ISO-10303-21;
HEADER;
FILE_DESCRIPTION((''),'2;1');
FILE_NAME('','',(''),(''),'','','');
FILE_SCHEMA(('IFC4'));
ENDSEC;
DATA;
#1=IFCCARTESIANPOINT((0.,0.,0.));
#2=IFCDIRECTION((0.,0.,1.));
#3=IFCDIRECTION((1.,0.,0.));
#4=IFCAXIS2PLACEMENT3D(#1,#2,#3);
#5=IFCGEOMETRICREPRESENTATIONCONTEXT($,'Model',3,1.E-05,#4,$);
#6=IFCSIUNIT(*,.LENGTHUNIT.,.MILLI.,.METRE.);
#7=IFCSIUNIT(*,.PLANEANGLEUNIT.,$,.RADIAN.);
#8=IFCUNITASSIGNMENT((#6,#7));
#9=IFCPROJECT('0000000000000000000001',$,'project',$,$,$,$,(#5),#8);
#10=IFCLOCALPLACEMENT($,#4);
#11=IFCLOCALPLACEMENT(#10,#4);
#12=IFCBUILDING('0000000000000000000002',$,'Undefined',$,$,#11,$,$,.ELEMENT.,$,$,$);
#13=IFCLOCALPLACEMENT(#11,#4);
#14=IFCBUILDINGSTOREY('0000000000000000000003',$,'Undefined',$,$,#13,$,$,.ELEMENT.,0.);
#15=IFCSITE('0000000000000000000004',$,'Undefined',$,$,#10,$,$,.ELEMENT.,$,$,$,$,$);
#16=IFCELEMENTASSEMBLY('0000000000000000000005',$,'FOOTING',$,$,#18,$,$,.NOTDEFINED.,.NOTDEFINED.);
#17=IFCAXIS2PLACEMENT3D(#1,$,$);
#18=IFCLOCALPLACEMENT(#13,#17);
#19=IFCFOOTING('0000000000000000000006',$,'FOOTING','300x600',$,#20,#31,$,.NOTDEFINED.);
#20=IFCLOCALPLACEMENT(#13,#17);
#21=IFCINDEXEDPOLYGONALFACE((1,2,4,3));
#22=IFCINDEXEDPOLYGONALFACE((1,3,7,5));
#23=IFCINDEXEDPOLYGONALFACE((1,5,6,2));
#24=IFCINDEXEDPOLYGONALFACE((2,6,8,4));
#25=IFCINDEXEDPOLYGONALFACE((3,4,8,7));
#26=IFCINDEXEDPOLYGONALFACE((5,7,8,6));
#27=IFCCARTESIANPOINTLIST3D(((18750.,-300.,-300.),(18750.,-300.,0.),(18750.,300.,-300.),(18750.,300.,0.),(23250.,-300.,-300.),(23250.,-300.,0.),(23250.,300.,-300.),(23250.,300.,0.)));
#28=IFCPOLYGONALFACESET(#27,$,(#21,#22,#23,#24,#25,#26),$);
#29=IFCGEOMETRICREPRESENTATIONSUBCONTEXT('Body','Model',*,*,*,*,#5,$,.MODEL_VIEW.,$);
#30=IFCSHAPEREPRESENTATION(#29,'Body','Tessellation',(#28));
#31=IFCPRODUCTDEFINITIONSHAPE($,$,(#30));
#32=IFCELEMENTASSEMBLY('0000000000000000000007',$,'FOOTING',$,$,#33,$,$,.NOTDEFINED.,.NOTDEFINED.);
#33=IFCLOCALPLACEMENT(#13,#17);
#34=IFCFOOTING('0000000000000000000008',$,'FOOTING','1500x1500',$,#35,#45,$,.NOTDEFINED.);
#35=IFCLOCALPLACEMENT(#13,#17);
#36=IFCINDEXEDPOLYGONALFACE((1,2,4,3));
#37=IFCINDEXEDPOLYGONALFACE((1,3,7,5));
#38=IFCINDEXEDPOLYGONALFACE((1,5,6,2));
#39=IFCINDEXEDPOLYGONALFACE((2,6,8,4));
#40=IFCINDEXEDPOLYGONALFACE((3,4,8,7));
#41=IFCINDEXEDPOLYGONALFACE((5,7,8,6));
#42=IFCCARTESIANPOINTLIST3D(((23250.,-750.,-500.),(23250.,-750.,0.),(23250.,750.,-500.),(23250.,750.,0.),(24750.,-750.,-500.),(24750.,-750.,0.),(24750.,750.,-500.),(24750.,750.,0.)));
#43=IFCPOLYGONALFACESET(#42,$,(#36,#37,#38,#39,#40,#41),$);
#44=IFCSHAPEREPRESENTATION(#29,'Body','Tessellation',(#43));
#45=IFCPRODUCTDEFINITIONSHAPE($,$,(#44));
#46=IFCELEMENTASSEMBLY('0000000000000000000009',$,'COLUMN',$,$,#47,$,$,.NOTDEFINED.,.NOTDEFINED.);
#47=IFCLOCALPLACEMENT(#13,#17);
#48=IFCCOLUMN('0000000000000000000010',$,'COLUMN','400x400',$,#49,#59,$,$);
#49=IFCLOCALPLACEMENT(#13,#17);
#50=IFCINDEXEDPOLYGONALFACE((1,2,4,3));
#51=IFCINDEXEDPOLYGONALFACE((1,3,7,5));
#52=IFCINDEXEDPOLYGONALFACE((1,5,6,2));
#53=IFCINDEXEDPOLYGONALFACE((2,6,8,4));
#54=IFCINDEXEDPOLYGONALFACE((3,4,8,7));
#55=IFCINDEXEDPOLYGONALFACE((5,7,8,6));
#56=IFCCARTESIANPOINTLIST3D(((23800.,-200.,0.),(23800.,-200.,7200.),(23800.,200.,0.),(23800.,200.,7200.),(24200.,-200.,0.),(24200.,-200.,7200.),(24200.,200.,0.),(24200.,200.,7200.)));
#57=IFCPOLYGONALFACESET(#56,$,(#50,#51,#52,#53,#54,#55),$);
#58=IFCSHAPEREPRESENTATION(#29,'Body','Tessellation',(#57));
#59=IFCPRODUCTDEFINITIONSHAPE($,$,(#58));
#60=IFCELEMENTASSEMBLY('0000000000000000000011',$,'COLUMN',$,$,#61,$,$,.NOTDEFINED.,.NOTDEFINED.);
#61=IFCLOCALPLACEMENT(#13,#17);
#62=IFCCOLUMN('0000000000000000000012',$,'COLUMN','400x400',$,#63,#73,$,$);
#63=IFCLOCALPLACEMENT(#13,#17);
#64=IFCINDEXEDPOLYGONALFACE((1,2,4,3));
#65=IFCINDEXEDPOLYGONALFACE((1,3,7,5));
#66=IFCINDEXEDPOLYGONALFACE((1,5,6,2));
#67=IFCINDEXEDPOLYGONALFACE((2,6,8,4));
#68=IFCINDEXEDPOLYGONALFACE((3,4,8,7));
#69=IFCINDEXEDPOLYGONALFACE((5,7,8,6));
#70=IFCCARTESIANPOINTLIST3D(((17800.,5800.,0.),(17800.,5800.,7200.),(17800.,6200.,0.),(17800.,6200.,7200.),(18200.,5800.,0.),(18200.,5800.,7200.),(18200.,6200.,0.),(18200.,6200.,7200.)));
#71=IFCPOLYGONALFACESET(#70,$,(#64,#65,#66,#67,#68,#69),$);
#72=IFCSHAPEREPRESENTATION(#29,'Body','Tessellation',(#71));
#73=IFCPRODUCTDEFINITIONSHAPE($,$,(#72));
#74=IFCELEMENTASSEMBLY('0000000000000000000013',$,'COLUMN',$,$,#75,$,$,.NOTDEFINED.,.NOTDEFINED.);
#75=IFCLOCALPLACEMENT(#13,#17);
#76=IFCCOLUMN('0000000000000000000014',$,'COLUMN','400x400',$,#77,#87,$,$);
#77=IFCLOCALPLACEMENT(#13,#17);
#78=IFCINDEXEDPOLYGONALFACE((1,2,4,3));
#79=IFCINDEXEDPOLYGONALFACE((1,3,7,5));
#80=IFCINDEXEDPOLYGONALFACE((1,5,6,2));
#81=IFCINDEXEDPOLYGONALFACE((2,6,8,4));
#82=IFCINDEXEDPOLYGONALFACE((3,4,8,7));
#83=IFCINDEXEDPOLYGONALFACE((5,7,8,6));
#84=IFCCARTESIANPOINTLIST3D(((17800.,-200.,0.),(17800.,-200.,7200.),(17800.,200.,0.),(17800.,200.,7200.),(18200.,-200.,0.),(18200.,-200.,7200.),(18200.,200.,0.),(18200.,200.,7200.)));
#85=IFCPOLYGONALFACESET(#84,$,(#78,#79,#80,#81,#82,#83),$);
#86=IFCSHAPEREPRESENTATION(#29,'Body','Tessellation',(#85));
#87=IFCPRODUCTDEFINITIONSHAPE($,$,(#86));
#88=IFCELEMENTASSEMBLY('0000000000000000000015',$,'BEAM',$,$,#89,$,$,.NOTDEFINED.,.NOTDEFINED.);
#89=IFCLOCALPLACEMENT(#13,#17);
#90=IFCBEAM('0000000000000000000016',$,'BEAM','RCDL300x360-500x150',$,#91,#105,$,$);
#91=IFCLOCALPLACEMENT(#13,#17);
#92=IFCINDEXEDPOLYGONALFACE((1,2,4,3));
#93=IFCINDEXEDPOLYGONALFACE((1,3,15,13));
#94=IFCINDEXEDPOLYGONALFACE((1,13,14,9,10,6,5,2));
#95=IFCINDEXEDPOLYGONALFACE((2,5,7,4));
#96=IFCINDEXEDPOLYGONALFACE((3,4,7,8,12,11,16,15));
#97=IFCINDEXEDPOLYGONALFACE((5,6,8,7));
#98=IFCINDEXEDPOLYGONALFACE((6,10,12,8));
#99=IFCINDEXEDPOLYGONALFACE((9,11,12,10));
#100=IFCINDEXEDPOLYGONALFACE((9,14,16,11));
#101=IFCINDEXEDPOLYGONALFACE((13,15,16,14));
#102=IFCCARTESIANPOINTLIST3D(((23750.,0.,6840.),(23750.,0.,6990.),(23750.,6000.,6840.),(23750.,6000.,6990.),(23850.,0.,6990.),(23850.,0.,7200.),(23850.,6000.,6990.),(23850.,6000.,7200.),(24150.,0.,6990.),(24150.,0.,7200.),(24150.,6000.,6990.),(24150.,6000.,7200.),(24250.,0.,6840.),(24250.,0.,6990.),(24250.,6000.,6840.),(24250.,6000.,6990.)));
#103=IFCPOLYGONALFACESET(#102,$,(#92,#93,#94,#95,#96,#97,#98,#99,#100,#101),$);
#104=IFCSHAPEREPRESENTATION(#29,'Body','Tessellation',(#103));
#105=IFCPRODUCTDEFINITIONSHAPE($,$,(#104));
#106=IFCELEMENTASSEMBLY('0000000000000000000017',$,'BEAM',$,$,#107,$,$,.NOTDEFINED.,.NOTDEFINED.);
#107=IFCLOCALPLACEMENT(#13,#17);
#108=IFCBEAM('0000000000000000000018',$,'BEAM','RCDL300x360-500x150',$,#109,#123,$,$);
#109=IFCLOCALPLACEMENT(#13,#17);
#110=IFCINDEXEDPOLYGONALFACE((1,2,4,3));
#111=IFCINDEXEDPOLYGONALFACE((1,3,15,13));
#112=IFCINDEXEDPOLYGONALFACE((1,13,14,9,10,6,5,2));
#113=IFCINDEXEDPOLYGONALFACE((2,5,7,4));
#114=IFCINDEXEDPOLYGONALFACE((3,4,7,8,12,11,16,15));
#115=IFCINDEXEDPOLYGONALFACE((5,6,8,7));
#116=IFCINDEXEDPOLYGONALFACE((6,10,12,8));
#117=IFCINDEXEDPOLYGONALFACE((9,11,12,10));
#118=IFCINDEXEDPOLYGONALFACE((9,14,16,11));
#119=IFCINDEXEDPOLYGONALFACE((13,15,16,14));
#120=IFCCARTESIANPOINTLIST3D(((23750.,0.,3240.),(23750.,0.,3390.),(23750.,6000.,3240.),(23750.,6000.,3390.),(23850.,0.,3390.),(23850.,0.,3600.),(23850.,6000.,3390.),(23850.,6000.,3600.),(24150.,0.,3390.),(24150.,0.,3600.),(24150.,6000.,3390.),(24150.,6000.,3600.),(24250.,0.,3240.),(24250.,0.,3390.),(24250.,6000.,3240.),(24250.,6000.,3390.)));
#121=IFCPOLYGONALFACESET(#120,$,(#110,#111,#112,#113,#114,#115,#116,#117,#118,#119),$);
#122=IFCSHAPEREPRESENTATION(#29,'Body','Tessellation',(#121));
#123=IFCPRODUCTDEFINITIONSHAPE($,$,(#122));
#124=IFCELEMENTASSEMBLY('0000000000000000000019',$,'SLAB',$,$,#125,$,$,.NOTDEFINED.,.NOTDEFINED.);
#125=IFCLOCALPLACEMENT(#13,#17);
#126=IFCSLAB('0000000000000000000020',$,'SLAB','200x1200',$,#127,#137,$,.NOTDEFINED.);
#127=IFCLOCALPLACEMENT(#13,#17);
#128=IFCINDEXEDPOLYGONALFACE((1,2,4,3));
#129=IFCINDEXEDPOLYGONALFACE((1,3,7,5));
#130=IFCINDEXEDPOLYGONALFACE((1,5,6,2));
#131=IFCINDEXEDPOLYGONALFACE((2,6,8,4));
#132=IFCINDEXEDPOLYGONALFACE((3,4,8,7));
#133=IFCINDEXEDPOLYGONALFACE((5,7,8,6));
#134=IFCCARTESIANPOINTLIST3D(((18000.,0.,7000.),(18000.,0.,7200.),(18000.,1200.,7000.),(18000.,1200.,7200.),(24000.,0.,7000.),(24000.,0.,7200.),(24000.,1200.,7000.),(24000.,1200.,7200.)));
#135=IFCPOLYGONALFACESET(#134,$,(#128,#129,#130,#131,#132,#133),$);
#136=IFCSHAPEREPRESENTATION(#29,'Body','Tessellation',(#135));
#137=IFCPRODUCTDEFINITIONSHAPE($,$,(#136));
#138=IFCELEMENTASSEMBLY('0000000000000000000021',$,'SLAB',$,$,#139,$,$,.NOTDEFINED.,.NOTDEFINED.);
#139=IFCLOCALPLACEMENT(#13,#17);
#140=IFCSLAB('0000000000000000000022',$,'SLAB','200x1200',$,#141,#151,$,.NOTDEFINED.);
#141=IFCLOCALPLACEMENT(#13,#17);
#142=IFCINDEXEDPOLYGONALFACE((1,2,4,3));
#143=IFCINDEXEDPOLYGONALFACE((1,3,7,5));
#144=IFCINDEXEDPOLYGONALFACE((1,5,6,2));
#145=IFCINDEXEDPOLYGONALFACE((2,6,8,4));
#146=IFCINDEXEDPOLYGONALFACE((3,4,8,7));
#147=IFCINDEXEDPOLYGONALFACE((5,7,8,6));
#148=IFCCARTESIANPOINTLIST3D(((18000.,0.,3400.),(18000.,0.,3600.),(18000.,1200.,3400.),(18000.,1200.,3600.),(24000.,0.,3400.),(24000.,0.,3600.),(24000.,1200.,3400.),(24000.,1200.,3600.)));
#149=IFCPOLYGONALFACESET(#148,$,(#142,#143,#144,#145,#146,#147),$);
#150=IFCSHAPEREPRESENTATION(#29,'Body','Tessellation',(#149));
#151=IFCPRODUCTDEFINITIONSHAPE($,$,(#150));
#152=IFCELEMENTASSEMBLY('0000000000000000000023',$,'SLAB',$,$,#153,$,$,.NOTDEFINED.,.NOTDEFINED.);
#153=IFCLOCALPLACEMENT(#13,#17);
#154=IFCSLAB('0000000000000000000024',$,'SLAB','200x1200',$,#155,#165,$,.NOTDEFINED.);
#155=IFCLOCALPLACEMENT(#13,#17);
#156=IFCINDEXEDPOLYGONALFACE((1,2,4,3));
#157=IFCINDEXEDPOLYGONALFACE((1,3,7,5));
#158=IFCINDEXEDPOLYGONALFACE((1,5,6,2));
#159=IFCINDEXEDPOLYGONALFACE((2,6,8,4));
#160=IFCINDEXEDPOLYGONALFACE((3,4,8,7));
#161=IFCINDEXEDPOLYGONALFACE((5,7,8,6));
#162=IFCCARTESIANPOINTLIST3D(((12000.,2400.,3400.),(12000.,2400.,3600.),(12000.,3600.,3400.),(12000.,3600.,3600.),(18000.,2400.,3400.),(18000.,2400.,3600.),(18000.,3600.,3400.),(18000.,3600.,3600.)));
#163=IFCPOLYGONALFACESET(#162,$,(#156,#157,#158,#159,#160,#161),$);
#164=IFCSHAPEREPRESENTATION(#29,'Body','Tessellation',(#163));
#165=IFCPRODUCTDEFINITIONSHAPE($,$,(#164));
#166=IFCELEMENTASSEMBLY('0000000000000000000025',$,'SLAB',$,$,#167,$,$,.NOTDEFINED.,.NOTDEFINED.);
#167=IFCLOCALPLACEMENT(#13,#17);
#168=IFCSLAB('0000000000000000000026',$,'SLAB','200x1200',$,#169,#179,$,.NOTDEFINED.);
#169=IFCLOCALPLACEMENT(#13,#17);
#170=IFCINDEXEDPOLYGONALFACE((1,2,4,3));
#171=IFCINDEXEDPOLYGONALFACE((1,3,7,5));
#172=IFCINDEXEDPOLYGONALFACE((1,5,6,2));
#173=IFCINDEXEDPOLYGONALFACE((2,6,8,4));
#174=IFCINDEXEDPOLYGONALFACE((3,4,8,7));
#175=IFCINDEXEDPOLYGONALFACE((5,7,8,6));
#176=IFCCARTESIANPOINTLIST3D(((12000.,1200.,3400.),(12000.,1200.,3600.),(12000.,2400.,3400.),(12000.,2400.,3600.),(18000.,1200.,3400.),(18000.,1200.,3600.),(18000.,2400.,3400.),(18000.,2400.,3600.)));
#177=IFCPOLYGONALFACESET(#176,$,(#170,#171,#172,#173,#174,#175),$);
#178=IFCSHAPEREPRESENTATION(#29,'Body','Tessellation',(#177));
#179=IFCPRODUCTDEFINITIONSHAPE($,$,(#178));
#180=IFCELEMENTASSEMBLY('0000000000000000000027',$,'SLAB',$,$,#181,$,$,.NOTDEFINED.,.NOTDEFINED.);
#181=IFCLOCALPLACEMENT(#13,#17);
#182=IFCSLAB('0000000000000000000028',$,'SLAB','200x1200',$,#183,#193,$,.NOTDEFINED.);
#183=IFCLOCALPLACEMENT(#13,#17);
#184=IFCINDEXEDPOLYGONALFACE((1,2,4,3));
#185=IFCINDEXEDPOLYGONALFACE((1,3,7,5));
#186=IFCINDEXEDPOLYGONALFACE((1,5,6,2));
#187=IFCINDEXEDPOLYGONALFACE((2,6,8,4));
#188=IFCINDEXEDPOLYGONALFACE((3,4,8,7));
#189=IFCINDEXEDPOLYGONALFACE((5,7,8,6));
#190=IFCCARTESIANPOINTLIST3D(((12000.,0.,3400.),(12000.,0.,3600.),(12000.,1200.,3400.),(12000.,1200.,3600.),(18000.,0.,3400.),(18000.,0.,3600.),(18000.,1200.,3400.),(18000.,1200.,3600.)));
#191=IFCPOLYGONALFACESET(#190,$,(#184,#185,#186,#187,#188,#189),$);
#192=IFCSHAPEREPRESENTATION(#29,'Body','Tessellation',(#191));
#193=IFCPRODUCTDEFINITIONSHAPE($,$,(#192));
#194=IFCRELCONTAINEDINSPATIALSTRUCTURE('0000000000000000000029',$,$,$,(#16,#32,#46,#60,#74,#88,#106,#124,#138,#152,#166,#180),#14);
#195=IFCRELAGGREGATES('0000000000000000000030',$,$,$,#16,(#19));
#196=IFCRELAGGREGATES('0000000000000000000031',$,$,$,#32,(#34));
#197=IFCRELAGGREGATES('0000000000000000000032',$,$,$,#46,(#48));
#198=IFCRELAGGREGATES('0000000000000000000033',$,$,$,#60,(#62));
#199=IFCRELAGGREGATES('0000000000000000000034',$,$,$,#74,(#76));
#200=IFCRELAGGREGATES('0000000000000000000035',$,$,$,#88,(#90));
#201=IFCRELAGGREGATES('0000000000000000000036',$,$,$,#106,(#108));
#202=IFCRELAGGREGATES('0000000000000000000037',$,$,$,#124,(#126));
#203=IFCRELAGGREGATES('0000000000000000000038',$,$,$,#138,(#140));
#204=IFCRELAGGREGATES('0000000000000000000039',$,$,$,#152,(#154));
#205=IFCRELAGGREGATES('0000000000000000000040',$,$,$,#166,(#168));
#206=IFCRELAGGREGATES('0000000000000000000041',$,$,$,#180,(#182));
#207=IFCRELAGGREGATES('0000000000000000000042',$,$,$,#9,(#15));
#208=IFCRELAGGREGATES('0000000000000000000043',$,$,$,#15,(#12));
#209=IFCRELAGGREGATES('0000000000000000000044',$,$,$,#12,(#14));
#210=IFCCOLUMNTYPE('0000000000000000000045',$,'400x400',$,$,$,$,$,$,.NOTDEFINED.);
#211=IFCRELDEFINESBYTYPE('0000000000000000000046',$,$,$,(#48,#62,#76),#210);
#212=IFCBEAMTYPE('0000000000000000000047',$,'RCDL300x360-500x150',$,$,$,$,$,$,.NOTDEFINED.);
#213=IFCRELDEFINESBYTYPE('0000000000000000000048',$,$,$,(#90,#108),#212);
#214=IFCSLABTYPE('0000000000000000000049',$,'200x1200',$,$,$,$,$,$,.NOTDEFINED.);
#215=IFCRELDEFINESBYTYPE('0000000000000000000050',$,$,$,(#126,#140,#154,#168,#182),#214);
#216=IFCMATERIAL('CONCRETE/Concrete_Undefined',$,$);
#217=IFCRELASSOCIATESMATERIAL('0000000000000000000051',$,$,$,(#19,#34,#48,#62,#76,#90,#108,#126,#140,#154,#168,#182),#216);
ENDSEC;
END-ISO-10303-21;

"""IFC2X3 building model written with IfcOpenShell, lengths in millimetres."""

from ifc_helpers import new_model, si_unit, frame, origin_with_axes, origin_2d_with_axis, place, context, subcontext, project, spatial, polyline, rectangle, outline, extrude, material, type_object, element, aggregate, save


model = new_model("IFC2X3")

# Units and contexts
model_context = context("Model", 3, precision=1e-05, world=origin_with_axes())
body_context = subcontext(model_context, "Body", "Model", "MODEL_VIEW")
ifc_project = project(units=[si_unit("LENGTHUNIT", "METRE", prefix="MILLI"), si_unit("PLANEANGLEUNIT", "RADIAN")], contexts=[model_context])

# Site, building, storey
site_placement = place(None, origin_with_axes())
site = spatial("IfcSite", under=ifc_project, at=site_placement, Name="Undefined", CompositionType="ELEMENT")
building_placement = place(site_placement, origin_with_axes())
building = spatial("IfcBuilding", under=site, at=building_placement, Name="Undefined", CompositionType="ELEMENT")
storey_placement = place(building_placement, origin_with_axes())
storey = spatial("IfcBuildingStorey", under=building, at=storey_placement, Name="Undefined", CompositionType="ELEMENT", Elevation=0.0)

# Element assemblies, footings
assembly_1_placement = place(storey_placement, origin_with_axes())
assembly_1 = element("IfcElementAssembly", 1, at=assembly_1_placement, inside=storey, Name="FOOTING", AssemblyPlace="NOTDEFINED", PredefinedType="NOTDEFINED")
ifc_material_1 = material(Name="CONCRETE/Concrete_Undefined")
footing_1_placement = place(assembly_1_placement, frame((18750.0, 0.0, -150.0), z_axis=(0.0, 0.0, 1.0), x_axis=(1.0, 0.0, 0.0)))
footing_1 = element("IfcFooting", 2, at=footing_1_placement, material=ifc_material_1, Name="FOOTING", Description="300x600", PredefinedType="NOTDEFINED", context=body_context, shape_type="SweptSolid", body=[
    extrude(rectangle(XDim=600.0, YDim=300.0, at=origin_2d_with_axis()), frame((4500.0, 0.0, 0.0), z_axis=(-1.0, 0.0, 0.0), x_axis=(0.0, -1.0, 0.0)), (0.0, 0.0, 1.0), 4500.0),
])
aggregate(assembly_1, [footing_1])
assembly_2_placement = place(storey_placement, origin_with_axes())
assembly_2 = element("IfcElementAssembly", 3, at=assembly_2_placement, inside=storey, Name="FOOTING", AssemblyPlace="NOTDEFINED", PredefinedType="NOTDEFINED")
footing_2_placement = place(assembly_2_placement, frame((24000.0, 0.0, -500.0), z_axis=(0.0, 1.0, 0.0), x_axis=(0.0, 0.0, 1.0)))
footing_2 = element("IfcFooting", 4, at=footing_2_placement, material=ifc_material_1, Name="FOOTING", Description="1500x1500", PredefinedType="NOTDEFINED", context=body_context, shape_type="SweptSolid", body=[
    extrude(rectangle(XDim=1500.0, YDim=1500.0, at=origin_2d_with_axis()), frame((500.0, 0.0, 0.0), z_axis=(-1.0, 0.0, 0.0), x_axis=(0.0, -1.0, 0.0)), (0.0, 0.0, 1.0), 500.0),
])
aggregate(assembly_2, [footing_2])

# Element assemblies, columns
assembly_3_placement = place(storey_placement, origin_with_axes())
assembly_3 = element("IfcElementAssembly", 5, at=assembly_3_placement, inside=storey, Name="COLUMN", AssemblyPlace="NOTDEFINED", PredefinedType="NOTDEFINED")
column_type = type_object("IfcColumnType", Name="400x400", PredefinedType="NOTDEFINED")
column_1_placement = place(assembly_3_placement, frame((24000.0, 0.0, 0.0), z_axis=(0.0, 0.0, 1.0), x_axis=(0.0, 1.0, 0.0)))
column_1 = element("IfcColumn", 6, at=column_1_placement, type_object=column_type, material=ifc_material_1, Name="COLUMN", Description="400x400", context=body_context, shape_type="SweptSolid", body=[
    extrude(rectangle(XDim=400.0, YDim=400.0, at=origin_2d_with_axis()), frame((0.0, 0.0, 7200.0), z_axis=(0.0, 0.0, -1.0), x_axis=(0.0, 1.0, 0.0)), (0.0, 0.0, 1.0), 7200.0),
])
aggregate(assembly_3, [column_1])
assembly_4_placement = place(storey_placement, origin_with_axes())
assembly_4 = element("IfcElementAssembly", 7, at=assembly_4_placement, inside=storey, Name="COLUMN", AssemblyPlace="NOTDEFINED", PredefinedType="NOTDEFINED")
column_2_placement = place(assembly_4_placement, frame((18000.0, 6000.0, 0.0), z_axis=(0.0, 0.0, 1.0), x_axis=(0.0, 1.0, 0.0)))
column_2 = element("IfcColumn", 8, at=column_2_placement, type_object=column_type, material=ifc_material_1, Name="COLUMN", Description="400x400", context=body_context, shape_type="SweptSolid", body=[
    extrude(rectangle(XDim=400.0, YDim=400.0, at=origin_2d_with_axis()), frame((0.0, 0.0, 7200.0), z_axis=(0.0, 0.0, -1.0), x_axis=(0.0, 1.0, 0.0)), (0.0, 0.0, 1.0), 7200.0),
])
aggregate(assembly_4, [column_2])
assembly_5_placement = place(storey_placement, origin_with_axes())
assembly_5 = element("IfcElementAssembly", 9, at=assembly_5_placement, inside=storey, Name="COLUMN", AssemblyPlace="NOTDEFINED", PredefinedType="NOTDEFINED")
column_3_placement = place(assembly_5_placement, frame((18000.0, 0.0, 0.0), z_axis=(0.0, 0.0, 1.0), x_axis=(0.0, 1.0, 0.0)))
column_3 = element("IfcColumn", 10, at=column_3_placement, type_object=column_type, material=ifc_material_1, Name="COLUMN", Description="400x400", context=body_context, shape_type="SweptSolid", body=[
    extrude(rectangle(XDim=400.0, YDim=400.0, at=origin_2d_with_axis()), frame((0.0, 0.0, 7200.0), z_axis=(0.0, 0.0, -1.0), x_axis=(0.0, 1.0, 0.0)), (0.0, 0.0, 1.0), 7200.0),
])
aggregate(assembly_5, [column_3])

# Element assemblies, beams
assembly_6_placement = place(storey_placement, origin_with_axes())
assembly_6 = element("IfcElementAssembly", 11, at=assembly_6_placement, inside=storey, Name="BEAM", AssemblyPlace="NOTDEFINED", PredefinedType="NOTDEFINED")
beam_type_1 = type_object("IfcBeamType", Name="RCDL300x360-500x150", PredefinedType="NOTDEFINED")
beam_1_placement = place(assembly_6_placement, frame((24000.0, 0.0, 7020.0), z_axis=(0.0, 0.0, 1.0), x_axis=(0.0, 1.0, 0.0)))
beam_1 = element("IfcBeam", 12, at=beam_1_placement, type_object=beam_type_1, material=ifc_material_1, Name="BEAM", Description="RCDL300x360-500x150", context=body_context, shape_type="SweptSolid", body=[
    extrude(outline(polyline([(150.0, 180.0), (150.0, -30.0), (250.0, -30.0), (250.0, -180.0), (-250.0, -180.0), (-250.0, -30.0), (-150.0, -30.0), (-150.0, 180.0), (150.0, 180.0)])), frame((6000.0, 0.0, 0.0), z_axis=(-1.0, 0.0, 0.0), x_axis=(0.0, -1.0, 0.0)), (0.0, 0.0, 1.0), 6000.0),
])
aggregate(assembly_6, [beam_1])
assembly_7_placement = place(storey_placement, origin_with_axes())
assembly_7 = element("IfcElementAssembly", 13, at=assembly_7_placement, inside=storey, Name="BEAM", AssemblyPlace="NOTDEFINED", PredefinedType="NOTDEFINED")
beam_2_placement = place(assembly_7_placement, frame((24000.0, 0.0, 3420.0), z_axis=(0.0, 0.0, 1.0), x_axis=(0.0, 1.0, 0.0)))
beam_2 = element("IfcBeam", 14, at=beam_2_placement, type_object=beam_type_1, material=ifc_material_1, Name="BEAM", Description="RCDL300x360-500x150", context=body_context, shape_type="SweptSolid", body=[
    extrude(outline(polyline([(150.0, 180.0), (150.0, -30.0), (250.0, -30.0), (250.0, -180.0), (-250.0, -180.0), (-250.0, -30.0), (-150.0, -30.0), (-150.0, 180.0), (150.0, 180.0)])), frame((6000.0, 0.0, 0.0), z_axis=(-1.0, 0.0, 0.0), x_axis=(0.0, -1.0, 0.0)), (0.0, 0.0, 1.0), 6000.0),
])
aggregate(assembly_7, [beam_2])

# Element assemblies, slabs
assembly_8_placement = place(storey_placement, origin_with_axes())
assembly_8 = element("IfcElementAssembly", 15, at=assembly_8_placement, inside=storey, Name="SLAB", AssemblyPlace="NOTDEFINED", PredefinedType="NOTDEFINED")
slab_type = type_object("IfcSlabType", Name="200x1200", PredefinedType="NOTDEFINED")
slab_1_placement = place(assembly_8_placement, frame((24000.0, 0.0, 7100.0), z_axis=(0.0, 0.0, 1.0), x_axis=(0.0, 1.0, 0.0)))
slab_1 = element("IfcSlab", 16, at=slab_1_placement, type_object=slab_type, material=ifc_material_1, Name="SLAB", Description="200x1200", PredefinedType="NOTDEFINED", context=body_context, shape_type="SweptSolid", body=[
    extrude(outline(polyline([(0.0, 0.0), (1200.0, 0.0), (1200.0, 6000.0), (0.0, 6000.0), (0.0, 0.0)])), frame((0.0, 0.0, -100.0), z_axis=(0.0, 0.0, 1.0), x_axis=(1.0, 0.0, 0.0)), (0.0, 0.0, 1.0), 200.0),
])
aggregate(assembly_8, [slab_1])
assembly_9_placement = place(storey_placement, origin_with_axes())
assembly_9 = element("IfcElementAssembly", 17, at=assembly_9_placement, inside=storey, Name="SLAB", AssemblyPlace="NOTDEFINED", PredefinedType="NOTDEFINED")
slab_2_placement = place(assembly_9_placement, frame((24000.0, 0.0, 3500.0), z_axis=(0.0, 0.0, 1.0), x_axis=(0.0, 1.0, 0.0)))
slab_2 = element("IfcSlab", 18, at=slab_2_placement, type_object=slab_type, material=ifc_material_1, Name="SLAB", Description="200x1200", PredefinedType="NOTDEFINED", context=body_context, shape_type="SweptSolid", body=[
    extrude(outline(polyline([(0.0, 0.0), (1200.0, 0.0), (1200.0, 6000.0), (0.0, 6000.0), (0.0, 0.0)])), frame((0.0, 0.0, -100.0), z_axis=(0.0, 0.0, 1.0), x_axis=(1.0, 0.0, 0.0)), (0.0, 0.0, 1.0), 200.0),
])
aggregate(assembly_9, [slab_2])
assembly_10_placement = place(storey_placement, origin_with_axes())
assembly_10 = element("IfcElementAssembly", 19, at=assembly_10_placement, inside=storey, Name="SLAB", AssemblyPlace="NOTDEFINED", PredefinedType="NOTDEFINED")
slab_3_placement = place(assembly_10_placement, frame((18000.0, 2400.0, 3500.0), z_axis=(0.0, 0.0, 1.0), x_axis=(0.0, 1.0, 0.0)))
slab_3 = element("IfcSlab", 20, at=slab_3_placement, type_object=slab_type, material=ifc_material_1, Name="SLAB", Description="200x1200", PredefinedType="NOTDEFINED", context=body_context, shape_type="SweptSolid", body=[
    extrude(outline(polyline([(0.0, 0.0), (1200.0, 0.0), (1200.0, 6000.0), (0.0, 6000.0), (0.0, 0.0)])), frame((0.0, 0.0, -100.0), z_axis=(0.0, 0.0, 1.0), x_axis=(1.0, 0.0, 0.0)), (0.0, 0.0, 1.0), 200.0),
])
aggregate(assembly_10, [slab_3])
assembly_11_placement = place(storey_placement, origin_with_axes())
assembly_11 = element("IfcElementAssembly", 21, at=assembly_11_placement, inside=storey, Name="SLAB", AssemblyPlace="NOTDEFINED", PredefinedType="NOTDEFINED")
slab_4_placement = place(assembly_11_placement, frame((18000.0, 1200.0, 3500.0), z_axis=(0.0, 0.0, 1.0), x_axis=(0.0, 1.0, 0.0)))
slab_4 = element("IfcSlab", 22, at=slab_4_placement, type_object=slab_type, material=ifc_material_1, Name="SLAB", Description="200x1200", PredefinedType="NOTDEFINED", context=body_context, shape_type="SweptSolid", body=[
    extrude(outline(polyline([(0.0, 0.0), (1200.0, 0.0), (1200.0, 6000.0), (0.0, 6000.0), (0.0, 0.0)])), frame((0.0, 0.0, -100.0), z_axis=(0.0, 0.0, 1.0), x_axis=(1.0, 0.0, 0.0)), (0.0, 0.0, 1.0), 200.0),
])
aggregate(assembly_11, [slab_4])
assembly_12_placement = place(storey_placement, origin_with_axes())
assembly_12 = element("IfcElementAssembly", 23, at=assembly_12_placement, inside=storey, Name="SLAB", AssemblyPlace="NOTDEFINED", PredefinedType="NOTDEFINED")
slab_5_placement = place(assembly_12_placement, frame((18000.0, 0.0, 3500.0), z_axis=(0.0, 0.0, 1.0), x_axis=(0.0, 1.0, 0.0)))
slab_5 = element("IfcSlab", 24, at=slab_5_placement, type_object=slab_type, material=ifc_material_1, Name="SLAB", Description="200x1200", PredefinedType="NOTDEFINED", context=body_context, shape_type="SweptSolid", body=[
    extrude(outline(polyline([(0.0, 0.0), (1200.0, 0.0), (1200.0, 6000.0), (0.0, 6000.0), (0.0, 0.0)])), frame((0.0, 0.0, -100.0), z_axis=(0.0, 0.0, 1.0), x_axis=(1.0, 0.0, 0.0)), (0.0, 0.0, 1.0), 200.0),
])
aggregate(assembly_12, [slab_5])

save(model, "model.ifc")
